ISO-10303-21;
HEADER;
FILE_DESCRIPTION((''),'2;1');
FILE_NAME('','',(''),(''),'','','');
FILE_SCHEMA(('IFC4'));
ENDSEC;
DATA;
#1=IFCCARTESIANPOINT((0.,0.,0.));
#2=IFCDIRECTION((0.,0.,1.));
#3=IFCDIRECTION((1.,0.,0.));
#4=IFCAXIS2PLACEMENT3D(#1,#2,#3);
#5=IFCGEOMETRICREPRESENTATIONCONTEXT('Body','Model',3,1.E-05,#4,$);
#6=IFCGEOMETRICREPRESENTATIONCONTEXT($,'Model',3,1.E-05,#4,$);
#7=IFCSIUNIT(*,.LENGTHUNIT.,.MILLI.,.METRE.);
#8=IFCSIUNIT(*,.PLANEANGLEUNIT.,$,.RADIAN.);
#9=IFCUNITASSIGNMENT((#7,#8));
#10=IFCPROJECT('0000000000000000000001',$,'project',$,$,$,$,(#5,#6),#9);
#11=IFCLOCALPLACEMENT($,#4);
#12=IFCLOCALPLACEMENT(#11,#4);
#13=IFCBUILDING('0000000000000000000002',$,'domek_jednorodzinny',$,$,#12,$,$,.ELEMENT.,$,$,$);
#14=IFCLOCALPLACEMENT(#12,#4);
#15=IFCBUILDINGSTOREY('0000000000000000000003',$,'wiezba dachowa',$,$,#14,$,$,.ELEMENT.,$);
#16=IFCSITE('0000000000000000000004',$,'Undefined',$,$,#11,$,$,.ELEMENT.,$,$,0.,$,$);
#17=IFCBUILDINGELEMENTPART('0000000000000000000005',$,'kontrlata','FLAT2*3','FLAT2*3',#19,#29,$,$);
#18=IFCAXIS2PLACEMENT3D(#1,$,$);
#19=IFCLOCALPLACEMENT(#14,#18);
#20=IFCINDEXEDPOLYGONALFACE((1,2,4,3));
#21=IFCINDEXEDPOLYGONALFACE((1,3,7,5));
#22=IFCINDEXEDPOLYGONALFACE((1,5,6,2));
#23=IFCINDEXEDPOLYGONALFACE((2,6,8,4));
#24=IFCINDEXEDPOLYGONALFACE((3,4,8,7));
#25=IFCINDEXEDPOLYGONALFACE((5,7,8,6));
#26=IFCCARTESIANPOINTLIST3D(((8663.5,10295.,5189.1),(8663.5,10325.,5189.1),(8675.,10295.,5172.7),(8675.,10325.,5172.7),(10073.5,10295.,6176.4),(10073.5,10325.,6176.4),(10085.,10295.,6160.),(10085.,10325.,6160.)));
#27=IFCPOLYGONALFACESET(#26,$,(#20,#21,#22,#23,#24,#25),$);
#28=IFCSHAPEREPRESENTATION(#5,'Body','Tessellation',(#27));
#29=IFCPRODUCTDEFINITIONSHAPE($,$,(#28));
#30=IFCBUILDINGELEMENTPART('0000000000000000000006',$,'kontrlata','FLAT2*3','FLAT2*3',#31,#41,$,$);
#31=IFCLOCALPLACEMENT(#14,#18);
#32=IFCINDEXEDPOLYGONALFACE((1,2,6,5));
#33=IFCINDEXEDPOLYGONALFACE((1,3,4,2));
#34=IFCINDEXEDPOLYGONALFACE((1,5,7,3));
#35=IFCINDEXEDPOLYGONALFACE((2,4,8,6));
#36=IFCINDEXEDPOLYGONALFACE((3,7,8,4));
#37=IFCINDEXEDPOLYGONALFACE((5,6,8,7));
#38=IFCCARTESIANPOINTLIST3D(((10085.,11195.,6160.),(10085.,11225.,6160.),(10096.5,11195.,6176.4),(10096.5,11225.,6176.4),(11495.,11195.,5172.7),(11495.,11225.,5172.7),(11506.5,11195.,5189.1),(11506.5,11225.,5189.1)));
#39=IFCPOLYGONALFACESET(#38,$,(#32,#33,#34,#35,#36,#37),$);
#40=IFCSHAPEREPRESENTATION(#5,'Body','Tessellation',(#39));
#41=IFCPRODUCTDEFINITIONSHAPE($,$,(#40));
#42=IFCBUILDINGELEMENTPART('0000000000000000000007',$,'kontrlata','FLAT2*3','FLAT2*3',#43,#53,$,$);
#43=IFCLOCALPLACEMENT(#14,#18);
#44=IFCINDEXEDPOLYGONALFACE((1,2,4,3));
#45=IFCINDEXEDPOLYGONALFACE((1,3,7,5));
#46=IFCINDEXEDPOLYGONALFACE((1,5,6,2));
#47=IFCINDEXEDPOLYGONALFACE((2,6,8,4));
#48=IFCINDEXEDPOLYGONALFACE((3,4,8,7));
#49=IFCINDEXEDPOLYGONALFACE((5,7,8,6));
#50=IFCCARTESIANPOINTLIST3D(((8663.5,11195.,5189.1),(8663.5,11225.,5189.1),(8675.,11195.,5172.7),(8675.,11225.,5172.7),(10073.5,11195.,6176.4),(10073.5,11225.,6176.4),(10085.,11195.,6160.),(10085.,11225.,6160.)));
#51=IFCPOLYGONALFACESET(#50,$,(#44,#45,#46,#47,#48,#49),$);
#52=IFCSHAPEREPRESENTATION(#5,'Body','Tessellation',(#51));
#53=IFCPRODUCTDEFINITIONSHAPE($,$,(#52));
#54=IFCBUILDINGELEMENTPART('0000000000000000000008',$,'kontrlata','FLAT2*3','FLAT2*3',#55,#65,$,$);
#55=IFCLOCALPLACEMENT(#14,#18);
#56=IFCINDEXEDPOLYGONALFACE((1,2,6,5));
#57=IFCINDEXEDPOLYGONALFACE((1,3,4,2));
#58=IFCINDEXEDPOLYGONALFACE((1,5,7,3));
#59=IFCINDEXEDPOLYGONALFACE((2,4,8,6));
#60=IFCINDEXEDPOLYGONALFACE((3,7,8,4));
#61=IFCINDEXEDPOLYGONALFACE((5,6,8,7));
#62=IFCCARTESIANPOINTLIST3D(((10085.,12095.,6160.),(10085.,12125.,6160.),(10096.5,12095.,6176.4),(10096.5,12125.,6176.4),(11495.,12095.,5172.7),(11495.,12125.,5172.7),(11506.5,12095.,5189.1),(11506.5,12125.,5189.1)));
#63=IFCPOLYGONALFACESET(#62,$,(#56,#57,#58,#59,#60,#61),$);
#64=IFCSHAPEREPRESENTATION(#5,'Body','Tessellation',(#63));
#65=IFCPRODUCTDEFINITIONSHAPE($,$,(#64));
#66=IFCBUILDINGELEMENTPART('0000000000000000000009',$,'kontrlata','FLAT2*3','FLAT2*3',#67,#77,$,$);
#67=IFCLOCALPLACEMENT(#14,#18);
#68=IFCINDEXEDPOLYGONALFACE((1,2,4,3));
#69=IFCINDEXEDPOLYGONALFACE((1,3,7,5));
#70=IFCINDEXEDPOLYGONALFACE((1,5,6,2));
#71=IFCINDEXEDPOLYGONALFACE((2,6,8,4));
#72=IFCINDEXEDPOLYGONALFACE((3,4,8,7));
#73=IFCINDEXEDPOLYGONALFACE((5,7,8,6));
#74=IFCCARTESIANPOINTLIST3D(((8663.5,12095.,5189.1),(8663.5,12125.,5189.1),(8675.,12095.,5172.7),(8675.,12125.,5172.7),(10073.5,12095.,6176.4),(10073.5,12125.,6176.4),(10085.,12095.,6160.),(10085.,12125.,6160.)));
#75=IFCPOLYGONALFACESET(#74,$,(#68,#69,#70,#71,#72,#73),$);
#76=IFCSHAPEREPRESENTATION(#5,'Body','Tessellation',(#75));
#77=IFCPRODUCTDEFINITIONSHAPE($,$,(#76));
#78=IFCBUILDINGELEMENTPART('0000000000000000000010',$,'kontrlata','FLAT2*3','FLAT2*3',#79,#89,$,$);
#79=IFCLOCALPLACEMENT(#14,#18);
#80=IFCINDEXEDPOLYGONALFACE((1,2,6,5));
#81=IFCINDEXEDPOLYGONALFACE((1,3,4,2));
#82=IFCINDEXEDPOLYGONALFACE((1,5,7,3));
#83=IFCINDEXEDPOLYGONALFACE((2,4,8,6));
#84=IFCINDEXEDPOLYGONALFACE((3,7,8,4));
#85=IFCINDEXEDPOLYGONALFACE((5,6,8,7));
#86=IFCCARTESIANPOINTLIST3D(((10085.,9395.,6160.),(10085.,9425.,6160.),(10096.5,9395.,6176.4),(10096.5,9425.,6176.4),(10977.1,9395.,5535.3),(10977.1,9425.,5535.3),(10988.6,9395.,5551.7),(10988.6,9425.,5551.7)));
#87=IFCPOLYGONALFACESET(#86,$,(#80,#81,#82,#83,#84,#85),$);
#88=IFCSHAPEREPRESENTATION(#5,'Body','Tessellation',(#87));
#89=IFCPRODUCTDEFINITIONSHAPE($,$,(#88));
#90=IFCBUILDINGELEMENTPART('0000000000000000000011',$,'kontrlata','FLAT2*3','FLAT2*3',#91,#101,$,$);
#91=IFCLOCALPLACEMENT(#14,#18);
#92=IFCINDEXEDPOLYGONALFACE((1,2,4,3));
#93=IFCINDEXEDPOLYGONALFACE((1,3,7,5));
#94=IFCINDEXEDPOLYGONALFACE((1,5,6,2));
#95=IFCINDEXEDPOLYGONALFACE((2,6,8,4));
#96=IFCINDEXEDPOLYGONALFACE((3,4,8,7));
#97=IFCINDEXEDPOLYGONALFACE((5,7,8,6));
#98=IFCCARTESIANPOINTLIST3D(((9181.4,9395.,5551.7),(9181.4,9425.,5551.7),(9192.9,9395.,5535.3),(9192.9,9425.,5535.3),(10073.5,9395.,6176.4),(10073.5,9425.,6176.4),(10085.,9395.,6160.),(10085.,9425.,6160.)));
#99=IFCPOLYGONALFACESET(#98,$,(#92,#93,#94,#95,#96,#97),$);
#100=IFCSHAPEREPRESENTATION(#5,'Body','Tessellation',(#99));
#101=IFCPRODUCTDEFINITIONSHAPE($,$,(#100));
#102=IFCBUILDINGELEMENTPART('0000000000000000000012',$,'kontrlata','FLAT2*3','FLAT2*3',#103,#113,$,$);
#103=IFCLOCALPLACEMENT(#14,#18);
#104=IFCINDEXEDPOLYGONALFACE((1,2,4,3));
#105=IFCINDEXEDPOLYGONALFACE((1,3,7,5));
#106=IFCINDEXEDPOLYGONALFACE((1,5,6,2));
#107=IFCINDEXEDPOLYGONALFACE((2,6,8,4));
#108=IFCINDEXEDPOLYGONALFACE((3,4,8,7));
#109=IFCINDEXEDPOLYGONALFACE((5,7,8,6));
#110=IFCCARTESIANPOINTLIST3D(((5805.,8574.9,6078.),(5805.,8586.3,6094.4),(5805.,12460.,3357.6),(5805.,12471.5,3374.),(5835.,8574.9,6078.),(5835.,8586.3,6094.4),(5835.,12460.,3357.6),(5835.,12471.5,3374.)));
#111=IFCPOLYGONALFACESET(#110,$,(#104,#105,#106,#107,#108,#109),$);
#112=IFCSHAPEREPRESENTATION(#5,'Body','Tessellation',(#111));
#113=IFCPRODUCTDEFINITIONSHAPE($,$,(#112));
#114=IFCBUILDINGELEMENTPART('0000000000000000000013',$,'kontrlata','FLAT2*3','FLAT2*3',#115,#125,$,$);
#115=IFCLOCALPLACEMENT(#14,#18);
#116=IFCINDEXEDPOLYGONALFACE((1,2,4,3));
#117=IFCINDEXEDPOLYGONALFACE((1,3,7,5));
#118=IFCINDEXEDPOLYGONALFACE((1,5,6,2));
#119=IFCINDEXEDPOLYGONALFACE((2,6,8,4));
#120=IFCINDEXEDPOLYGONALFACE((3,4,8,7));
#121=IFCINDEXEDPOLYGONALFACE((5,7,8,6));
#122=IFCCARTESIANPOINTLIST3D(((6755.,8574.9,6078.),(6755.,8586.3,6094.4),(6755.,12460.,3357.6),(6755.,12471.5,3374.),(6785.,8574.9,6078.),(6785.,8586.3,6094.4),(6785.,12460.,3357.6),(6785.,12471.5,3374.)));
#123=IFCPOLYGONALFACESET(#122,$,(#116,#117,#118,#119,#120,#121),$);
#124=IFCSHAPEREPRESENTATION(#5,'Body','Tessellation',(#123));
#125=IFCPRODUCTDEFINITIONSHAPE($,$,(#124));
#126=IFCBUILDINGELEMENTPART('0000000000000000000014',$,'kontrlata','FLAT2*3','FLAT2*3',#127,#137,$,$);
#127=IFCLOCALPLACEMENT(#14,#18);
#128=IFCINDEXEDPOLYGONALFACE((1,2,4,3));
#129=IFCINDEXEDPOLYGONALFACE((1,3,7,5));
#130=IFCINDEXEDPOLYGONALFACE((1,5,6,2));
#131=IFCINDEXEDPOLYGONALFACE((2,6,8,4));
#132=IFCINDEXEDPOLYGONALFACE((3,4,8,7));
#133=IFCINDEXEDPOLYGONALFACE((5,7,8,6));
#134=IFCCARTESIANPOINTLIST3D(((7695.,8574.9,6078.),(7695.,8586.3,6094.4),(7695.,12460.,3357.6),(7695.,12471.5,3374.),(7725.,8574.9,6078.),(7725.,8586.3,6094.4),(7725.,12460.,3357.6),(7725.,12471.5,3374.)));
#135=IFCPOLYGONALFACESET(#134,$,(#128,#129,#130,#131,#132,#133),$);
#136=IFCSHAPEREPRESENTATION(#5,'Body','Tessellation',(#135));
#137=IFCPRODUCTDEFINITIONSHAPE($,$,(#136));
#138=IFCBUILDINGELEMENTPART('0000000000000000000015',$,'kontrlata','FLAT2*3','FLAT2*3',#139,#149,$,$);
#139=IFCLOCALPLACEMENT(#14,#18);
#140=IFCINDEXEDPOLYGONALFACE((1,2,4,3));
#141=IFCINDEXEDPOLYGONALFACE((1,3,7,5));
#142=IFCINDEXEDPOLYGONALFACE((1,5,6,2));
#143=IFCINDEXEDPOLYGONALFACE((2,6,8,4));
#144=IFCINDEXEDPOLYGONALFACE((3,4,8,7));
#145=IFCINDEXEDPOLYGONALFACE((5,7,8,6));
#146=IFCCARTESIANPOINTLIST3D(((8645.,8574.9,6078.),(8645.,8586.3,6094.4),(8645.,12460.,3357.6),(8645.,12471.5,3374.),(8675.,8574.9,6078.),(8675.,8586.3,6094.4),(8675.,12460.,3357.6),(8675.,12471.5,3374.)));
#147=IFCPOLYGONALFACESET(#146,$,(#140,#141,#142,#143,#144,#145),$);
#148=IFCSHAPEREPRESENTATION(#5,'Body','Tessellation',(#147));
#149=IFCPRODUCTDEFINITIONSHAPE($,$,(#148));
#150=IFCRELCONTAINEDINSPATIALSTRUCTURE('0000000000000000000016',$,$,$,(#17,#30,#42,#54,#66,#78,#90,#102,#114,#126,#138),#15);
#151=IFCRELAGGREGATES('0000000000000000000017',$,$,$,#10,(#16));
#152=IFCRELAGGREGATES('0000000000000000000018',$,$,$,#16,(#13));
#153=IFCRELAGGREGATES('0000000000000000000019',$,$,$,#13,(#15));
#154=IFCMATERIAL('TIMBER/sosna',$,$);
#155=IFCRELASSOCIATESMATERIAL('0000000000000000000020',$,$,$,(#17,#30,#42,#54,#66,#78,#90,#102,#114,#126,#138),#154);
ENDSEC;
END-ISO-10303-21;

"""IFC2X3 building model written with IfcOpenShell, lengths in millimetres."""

from ifc_helpers import new_model, si_unit, frame, origin_with_axes, origin_2d_with_axis, place, context, project, spatial, rectangle, extrude, material, element, save


model = new_model("IFC2X3")

# Units and contexts
model_context_1 = context("Model", 3, precision=1e-05, world=origin_with_axes(), identifier="Body")
model_context_2 = context("Model", 3, precision=1e-05, world=origin_with_axes())
ifc_project = project(units=[si_unit("LENGTHUNIT", "METRE", prefix="MILLI"), si_unit("PLANEANGLEUNIT", "RADIAN")], contexts=[model_context_1, model_context_2])

# Site, building, storey
site_placement = place(None, origin_with_axes())
site = spatial("IfcSite", under=ifc_project, at=site_placement, Name="Undefined", CompositionType="ELEMENT", RefElevation=0.0)
building_placement = place(site_placement, origin_with_axes())
building = spatial("IfcBuilding", under=site, at=building_placement, Name="domek_jednorodzinny", CompositionType="ELEMENT")
storey_placement = place(building_placement, origin_with_axes())
storey = spatial("IfcBuildingStorey", under=building, at=storey_placement, Name="wiezba dachowa", CompositionType="ELEMENT")

# Building element parts
ifc_material = material(Name="TIMBER/sosna")
building_element_part_1_placement = place(storey_placement, frame((8669.3, 10310.0, 5180.9), z_axis=(0.0, -1.0, 0.0), x_axis=(0.819152, 0.0, 0.573576)))
element("IfcBuildingElementPart", 1, at=building_element_part_1_placement, inside=storey, material=ifc_material, Name="kontrlata", Description="FLAT2*3", ObjectType="FLAT2*3", context=model_context_1, shape_type="SweptSolid", body=[
    extrude(rectangle(XDim=20.0, YDim=30.0, at=origin_2d_with_axis()), frame((1721.3, 0.0, 0.0), z_axis=(-1.0, 0.0, 0.0), x_axis=(0.0, -1.0, 0.0)), (0.0, 0.0, 1.0), 1721.3),
])
building_element_part_2_placement = place(storey_placement, frame((10090.7, 11210.0, 6168.2), z_axis=(0.0, -1.0, 0.0), x_axis=(0.819151, 0.0, -0.573578)))
element("IfcBuildingElementPart", 2, at=building_element_part_2_placement, inside=storey, material=ifc_material, Name="kontrlata", Description="FLAT2*3", ObjectType="FLAT2*3", context=model_context_1, shape_type="SweptSolid", body=[
    extrude(rectangle(XDim=20.0, YDim=30.0, at=origin_2d_with_axis()), frame((1721.3, 0.0, 0.0), z_axis=(-1.0, 0.0, 0.0), x_axis=(0.0, -1.0, 0.0)), (0.0, 0.0, 1.0), 1721.3),
])
building_element_part_3_placement = place(storey_placement, frame((8669.3, 11210.0, 5180.9), z_axis=(0.0, -1.0, 0.0), x_axis=(0.819152, 0.0, 0.573576)))
element("IfcBuildingElementPart", 3, at=building_element_part_3_placement, inside=storey, material=ifc_material, Name="kontrlata", Description="FLAT2*3", ObjectType="FLAT2*3", context=model_context_1, shape_type="SweptSolid", body=[
    extrude(rectangle(XDim=20.0, YDim=30.0, at=origin_2d_with_axis()), frame((1721.3, 0.0, 0.0), z_axis=(-1.0, 0.0, 0.0), x_axis=(0.0, -1.0, 0.0)), (0.0, 0.0, 1.0), 1721.3),
])
building_element_part_4_placement = place(storey_placement, frame((10090.7, 12110.0, 6168.2), z_axis=(0.0, -1.0, 0.0), x_axis=(0.819151, 0.0, -0.573578)))
element("IfcBuildingElementPart", 4, at=building_element_part_4_placement, inside=storey, material=ifc_material, Name="kontrlata", Description="FLAT2*3", ObjectType="FLAT2*3", context=model_context_1, shape_type="SweptSolid", body=[
    extrude(rectangle(XDim=20.0, YDim=30.0, at=origin_2d_with_axis()), frame((1721.3, 0.0, 0.0), z_axis=(-1.0, 0.0, 0.0), x_axis=(0.0, -1.0, 0.0)), (0.0, 0.0, 1.0), 1721.3),
])
building_element_part_5_placement = place(storey_placement, frame((8669.3, 12110.0, 5180.9), z_axis=(0.0, -1.0, 0.0), x_axis=(0.819152, 0.0, 0.573576)))
element("IfcBuildingElementPart", 5, at=building_element_part_5_placement, inside=storey, material=ifc_material, Name="kontrlata", Description="FLAT2*3", ObjectType="FLAT2*3", context=model_context_1, shape_type="SweptSolid", body=[
    extrude(rectangle(XDim=20.0, YDim=30.0, at=origin_2d_with_axis()), frame((1721.3, 0.0, 0.0), z_axis=(-1.0, 0.0, 0.0), x_axis=(0.0, -1.0, 0.0)), (0.0, 0.0, 1.0), 1721.3),
])
building_element_part_6_placement = place(storey_placement, frame((10090.7, 9410.0, 6168.2), z_axis=(0.0, -1.0, 0.0), x_axis=(0.819151, 0.0, -0.573578)))
element("IfcBuildingElementPart", 6, at=building_element_part_6_placement, inside=storey, material=ifc_material, Name="kontrlata", Description="FLAT2*3", ObjectType="FLAT2*3", context=model_context_1, shape_type="SweptSolid", body=[
    extrude(rectangle(XDim=20.0, YDim=30.0, at=origin_2d_with_axis()), frame((1089.1, 0.0, 0.0), z_axis=(-1.0, 0.0, 0.0), x_axis=(0.0, -1.0, 0.0)), (0.0, 0.0, 1.0), 1089.1),
])
building_element_part_7_placement = place(storey_placement, frame((9187.2, 9410.0, 5543.5), z_axis=(0.0, -1.0, 0.0), x_axis=(0.819152, 0.0, 0.573576)))
element("IfcBuildingElementPart", 7, at=building_element_part_7_placement, inside=storey, material=ifc_material, Name="kontrlata", Description="FLAT2*3", ObjectType="FLAT2*3", context=model_context_1, shape_type="SweptSolid", body=[
    extrude(rectangle(XDim=20.0, YDim=30.0, at=origin_2d_with_axis()), frame((1089.1, 0.0, 0.0), z_axis=(-1.0, 0.0, 0.0), x_axis=(0.0, -1.0, 0.0)), (0.0, 0.0, 1.0), 1089.1),
])
for number, where, z_axis, x_axis, name in (
    (8, (5820.0, 12465.7, 3365.8), (-1.0, 0.0, 0.0), (0.0, -0.819154, 0.573574), "kontrlata"),
    (9, (6770.0, 12465.7, 3365.8), (-1.0, 0.0, 0.0), (0.0, -0.819154, 0.573574), "kontrlata"),
    (10, (7710.0, 12465.7, 3365.8), (-1.0, 0.0, 0.0), (0.0, -0.819154, 0.573574), "kontrlata"),
    (11, (8660.0, 12465.7, 3365.8), (-1.0, 0.0, 0.0), (0.0, -0.819154, 0.573574), "kontrlata"),
):
    element("IfcBuildingElementPart", number, at=place(storey_placement, frame(where, z_axis=z_axis, x_axis=x_axis)), inside=storey, material=ifc_material, Name=name, Description="FLAT2*3", ObjectType="FLAT2*3", context=model_context_1, shape_type="SweptSolid", body=[
        extrude(rectangle(XDim=20.0, YDim=30.0, at=origin_2d_with_axis()), frame((4742.8, 0.0, 0.0), z_axis=(-1.0, 0.0, 0.0), x_axis=(0.0, -1.0, 0.0)), (0.0, 0.0, 1.0), 4742.8),
    ])

save(model, "model.ifc")
